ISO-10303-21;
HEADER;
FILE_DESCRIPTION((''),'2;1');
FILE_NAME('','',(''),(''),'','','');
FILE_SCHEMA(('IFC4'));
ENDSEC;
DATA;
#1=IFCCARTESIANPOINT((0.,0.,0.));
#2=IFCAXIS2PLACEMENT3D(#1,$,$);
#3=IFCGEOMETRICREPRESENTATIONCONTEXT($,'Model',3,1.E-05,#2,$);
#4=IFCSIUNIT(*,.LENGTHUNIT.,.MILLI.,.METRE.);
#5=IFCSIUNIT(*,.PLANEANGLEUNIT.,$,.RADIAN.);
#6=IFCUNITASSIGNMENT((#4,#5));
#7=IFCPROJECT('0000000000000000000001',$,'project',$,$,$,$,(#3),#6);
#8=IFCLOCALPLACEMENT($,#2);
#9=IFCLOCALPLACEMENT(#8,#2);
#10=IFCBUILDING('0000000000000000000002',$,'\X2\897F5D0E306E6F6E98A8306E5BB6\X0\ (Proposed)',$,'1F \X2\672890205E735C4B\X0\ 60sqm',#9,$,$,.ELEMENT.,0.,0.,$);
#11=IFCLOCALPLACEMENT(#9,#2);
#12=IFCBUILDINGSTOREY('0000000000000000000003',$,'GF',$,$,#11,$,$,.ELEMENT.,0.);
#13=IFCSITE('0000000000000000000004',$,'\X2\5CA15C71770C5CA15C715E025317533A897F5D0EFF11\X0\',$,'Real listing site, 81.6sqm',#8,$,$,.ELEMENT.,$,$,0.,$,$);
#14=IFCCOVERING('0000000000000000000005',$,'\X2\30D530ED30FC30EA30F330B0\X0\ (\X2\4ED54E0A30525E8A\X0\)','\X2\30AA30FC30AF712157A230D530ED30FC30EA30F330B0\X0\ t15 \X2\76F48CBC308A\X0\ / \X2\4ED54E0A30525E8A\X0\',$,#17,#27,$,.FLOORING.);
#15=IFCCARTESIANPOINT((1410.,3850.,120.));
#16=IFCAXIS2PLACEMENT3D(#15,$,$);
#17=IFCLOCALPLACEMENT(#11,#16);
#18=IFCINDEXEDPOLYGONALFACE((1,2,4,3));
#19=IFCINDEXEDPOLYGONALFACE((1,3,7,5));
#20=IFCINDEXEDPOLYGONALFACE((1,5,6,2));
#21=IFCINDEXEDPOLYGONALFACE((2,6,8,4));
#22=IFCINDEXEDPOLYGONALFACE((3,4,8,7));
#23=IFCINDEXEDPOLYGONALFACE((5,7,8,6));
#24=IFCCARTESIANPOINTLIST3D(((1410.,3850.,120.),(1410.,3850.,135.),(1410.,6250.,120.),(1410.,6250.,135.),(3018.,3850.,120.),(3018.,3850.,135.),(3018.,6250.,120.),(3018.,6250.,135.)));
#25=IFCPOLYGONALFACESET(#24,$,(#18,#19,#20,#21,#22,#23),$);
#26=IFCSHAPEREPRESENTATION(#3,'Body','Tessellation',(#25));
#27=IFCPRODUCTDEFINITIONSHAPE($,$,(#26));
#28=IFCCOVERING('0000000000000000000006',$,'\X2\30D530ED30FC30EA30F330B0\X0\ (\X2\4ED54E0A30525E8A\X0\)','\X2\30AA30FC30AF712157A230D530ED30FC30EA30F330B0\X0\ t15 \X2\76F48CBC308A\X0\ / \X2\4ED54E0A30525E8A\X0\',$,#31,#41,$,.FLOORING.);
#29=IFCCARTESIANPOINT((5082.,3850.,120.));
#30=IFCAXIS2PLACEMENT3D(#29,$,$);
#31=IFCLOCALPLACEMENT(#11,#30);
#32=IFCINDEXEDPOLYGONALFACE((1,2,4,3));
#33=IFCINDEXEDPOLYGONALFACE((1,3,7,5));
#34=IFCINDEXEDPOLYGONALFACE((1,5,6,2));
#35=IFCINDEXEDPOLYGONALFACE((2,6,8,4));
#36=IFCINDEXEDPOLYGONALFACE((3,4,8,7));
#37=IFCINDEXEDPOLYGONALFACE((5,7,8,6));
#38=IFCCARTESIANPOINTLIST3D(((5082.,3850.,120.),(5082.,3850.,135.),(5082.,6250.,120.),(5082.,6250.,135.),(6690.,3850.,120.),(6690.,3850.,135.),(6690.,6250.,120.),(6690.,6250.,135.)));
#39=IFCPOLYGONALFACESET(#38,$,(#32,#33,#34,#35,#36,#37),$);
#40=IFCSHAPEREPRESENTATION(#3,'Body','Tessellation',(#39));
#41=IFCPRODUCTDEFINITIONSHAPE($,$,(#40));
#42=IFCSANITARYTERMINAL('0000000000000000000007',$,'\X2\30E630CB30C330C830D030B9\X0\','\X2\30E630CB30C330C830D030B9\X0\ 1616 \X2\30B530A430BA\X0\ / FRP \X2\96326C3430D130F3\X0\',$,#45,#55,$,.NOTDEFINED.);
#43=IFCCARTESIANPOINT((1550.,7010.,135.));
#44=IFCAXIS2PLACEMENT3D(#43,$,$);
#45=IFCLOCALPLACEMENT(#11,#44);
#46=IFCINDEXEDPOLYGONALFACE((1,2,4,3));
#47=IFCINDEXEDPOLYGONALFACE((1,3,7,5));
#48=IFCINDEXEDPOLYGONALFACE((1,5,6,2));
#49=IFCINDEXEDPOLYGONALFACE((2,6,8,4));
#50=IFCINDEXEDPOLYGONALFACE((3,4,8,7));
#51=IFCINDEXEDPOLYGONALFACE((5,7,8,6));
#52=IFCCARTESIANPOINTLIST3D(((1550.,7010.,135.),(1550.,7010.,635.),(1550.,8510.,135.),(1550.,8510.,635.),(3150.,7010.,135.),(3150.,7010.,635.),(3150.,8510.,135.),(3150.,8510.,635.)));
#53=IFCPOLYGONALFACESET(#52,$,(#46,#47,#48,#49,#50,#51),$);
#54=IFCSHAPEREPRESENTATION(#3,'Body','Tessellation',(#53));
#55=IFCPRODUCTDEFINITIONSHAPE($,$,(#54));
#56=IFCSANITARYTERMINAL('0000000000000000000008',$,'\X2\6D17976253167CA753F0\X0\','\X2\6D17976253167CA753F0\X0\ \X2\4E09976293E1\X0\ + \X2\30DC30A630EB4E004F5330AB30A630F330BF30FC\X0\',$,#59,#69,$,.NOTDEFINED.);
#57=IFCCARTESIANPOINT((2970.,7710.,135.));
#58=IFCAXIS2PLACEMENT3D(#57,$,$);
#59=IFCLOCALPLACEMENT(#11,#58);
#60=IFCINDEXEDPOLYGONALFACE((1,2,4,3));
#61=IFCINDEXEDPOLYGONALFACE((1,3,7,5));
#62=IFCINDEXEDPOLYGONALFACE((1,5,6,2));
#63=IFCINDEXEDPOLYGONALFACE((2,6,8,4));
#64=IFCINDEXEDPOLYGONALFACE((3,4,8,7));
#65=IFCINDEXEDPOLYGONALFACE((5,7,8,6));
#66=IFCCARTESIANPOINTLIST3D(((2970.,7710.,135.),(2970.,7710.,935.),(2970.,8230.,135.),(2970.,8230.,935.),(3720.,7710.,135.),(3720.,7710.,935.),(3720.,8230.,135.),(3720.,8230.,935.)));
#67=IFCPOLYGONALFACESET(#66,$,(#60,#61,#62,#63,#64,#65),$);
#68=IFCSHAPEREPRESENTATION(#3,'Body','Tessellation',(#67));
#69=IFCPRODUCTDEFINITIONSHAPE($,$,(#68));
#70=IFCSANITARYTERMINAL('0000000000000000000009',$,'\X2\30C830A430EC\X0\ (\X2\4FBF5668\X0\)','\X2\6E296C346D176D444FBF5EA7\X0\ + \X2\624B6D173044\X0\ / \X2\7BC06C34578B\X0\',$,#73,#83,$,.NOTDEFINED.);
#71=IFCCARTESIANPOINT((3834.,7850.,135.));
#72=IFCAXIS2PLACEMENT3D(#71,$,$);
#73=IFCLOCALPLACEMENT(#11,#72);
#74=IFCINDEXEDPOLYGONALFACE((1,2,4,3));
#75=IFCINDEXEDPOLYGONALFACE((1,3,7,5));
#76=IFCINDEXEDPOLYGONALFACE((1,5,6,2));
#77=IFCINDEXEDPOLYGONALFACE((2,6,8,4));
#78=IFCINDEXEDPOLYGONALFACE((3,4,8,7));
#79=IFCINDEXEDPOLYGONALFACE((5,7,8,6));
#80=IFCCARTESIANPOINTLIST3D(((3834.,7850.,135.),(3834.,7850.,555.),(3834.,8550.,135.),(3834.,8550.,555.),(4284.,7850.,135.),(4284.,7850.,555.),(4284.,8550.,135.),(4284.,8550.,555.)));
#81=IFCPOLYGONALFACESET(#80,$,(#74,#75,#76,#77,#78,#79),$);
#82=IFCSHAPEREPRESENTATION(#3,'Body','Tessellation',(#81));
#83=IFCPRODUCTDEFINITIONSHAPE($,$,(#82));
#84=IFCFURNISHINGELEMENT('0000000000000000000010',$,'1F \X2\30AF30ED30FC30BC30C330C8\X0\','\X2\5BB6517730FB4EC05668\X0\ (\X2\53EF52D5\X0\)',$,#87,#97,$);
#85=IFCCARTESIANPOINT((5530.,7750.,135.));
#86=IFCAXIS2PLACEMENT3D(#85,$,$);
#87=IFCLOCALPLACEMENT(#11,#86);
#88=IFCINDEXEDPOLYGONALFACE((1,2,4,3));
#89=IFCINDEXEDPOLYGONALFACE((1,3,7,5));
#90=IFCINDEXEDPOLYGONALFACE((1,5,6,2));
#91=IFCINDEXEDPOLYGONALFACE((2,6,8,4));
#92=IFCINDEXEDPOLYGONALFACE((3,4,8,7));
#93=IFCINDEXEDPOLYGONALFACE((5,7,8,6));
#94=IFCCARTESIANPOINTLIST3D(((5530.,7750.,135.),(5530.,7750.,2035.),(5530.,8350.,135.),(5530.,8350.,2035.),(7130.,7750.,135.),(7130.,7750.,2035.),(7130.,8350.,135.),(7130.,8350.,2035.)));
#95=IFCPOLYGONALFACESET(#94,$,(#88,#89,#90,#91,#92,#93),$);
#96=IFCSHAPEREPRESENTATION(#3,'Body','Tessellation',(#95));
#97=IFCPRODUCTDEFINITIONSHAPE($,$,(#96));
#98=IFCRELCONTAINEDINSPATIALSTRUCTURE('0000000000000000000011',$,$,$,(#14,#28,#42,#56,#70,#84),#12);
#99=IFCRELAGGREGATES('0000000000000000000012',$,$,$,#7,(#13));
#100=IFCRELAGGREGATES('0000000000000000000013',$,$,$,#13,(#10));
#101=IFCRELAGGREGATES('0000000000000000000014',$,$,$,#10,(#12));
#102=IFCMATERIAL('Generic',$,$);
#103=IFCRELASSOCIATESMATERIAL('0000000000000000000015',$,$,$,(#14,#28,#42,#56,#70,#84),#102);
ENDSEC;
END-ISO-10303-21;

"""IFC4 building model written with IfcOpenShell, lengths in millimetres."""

from ifc_helpers import new_model, si_unit, frame, frame_2d, origin, place, context, project, spatial, rectangle, extrude, material, element, save


model = new_model("IFC4")

# Units and contexts
model_context = context("Model", 3, precision=1e-05, world=origin())
ifc_project = project(units=[si_unit("LENGTHUNIT", "METRE", prefix="MILLI"), si_unit("PLANEANGLEUNIT", "RADIAN")], contexts=[model_context])

# Site, building, storey
site_placement = place(None, origin())
site = spatial("IfcSite", under=ifc_project, at=site_placement, Name="岡山県岡山市北区西崎１", ObjectType="Real listing site, 81.6sqm", CompositionType="ELEMENT", RefElevation=0.0)
building_placement = place(site_placement, origin())
building = spatial("IfcBuilding", under=site, at=building_placement, Name="西崎の潮風の家 (Proposed)", ObjectType="1F 木造平屋 60sqm", CompositionType="ELEMENT", ElevationOfRefHeight=0.0, ElevationOfTerrain=0.0)
storey_placement = place(building_placement, origin())
storey = spatial("IfcBuildingStorey", under=building, at=storey_placement, Name="GF", CompositionType="ELEMENT", Elevation=0.0)

# Coverings
ifc_material_1 = material(Name="Generic")
covering_1_placement = place(storey_placement, frame((1410.0, 3850.0, 120.0)))
element("IfcCovering", 1, at=covering_1_placement, inside=storey, material=ifc_material_1, Name="フローリング (仕上げ床)", Description="オーク無垢フローリング t15 直貼り / 仕上げ床", PredefinedType="FLOORING", context=model_context, shape_type="SweptSolid", body=[
    extrude(rectangle(XDim=1608.0, YDim=2400.0, at=frame_2d((804.0, 1200.0))), frame((1410.0, 3850.0, 120.0)), (0.0, 0.0, 1.0), 15.0),
])
covering_2_placement = place(storey_placement, frame((5082.0, 3850.0, 120.0)))
element("IfcCovering", 2, at=covering_2_placement, inside=storey, material=ifc_material_1, Name="フローリング (仕上げ床)", Description="オーク無垢フローリング t15 直貼り / 仕上げ床", PredefinedType="FLOORING", context=model_context, shape_type="SweptSolid", body=[
    extrude(rectangle(XDim=1608.0, YDim=2400.0, at=frame_2d((804.0, 1200.0))), frame((5082.0, 3850.0, 120.0)), (0.0, 0.0, 1.0), 15.0),
])

# Sanitary terminals
sanitary_terminal_1_placement = place(storey_placement, frame((1550.0, 7010.0, 135.0)))
element("IfcSanitaryTerminal", 3, at=sanitary_terminal_1_placement, inside=storey, material=ifc_material_1, Name="ユニットバス", Description="ユニットバス 1616 サイズ / FRP 防水パン", PredefinedType="NOTDEFINED", context=model_context, shape_type="SweptSolid", body=[
    extrude(rectangle(XDim=1600.0, YDim=1500.0, at=frame_2d((800.0, 750.0))), frame((1550.0, 7010.0, 135.0)), (0.0, 0.0, 1.0), 500.0),
])
sanitary_terminal_2_placement = place(storey_placement, frame((2970.0, 7710.0, 135.0)))
element("IfcSanitaryTerminal", 4, at=sanitary_terminal_2_placement, inside=storey, material=ifc_material_1, Name="洗面化粧台", Description="洗面化粧台 三面鏡 + ボウル一体カウンター", PredefinedType="NOTDEFINED", context=model_context, shape_type="SweptSolid", body=[
    extrude(rectangle(XDim=750.0, YDim=520.0, at=frame_2d((375.0, 260.0))), frame((2970.0, 7710.0, 135.0)), (0.0, 0.0, 1.0), 800.0),
])
sanitary_terminal_3_placement = place(storey_placement, frame((3834.0, 7850.0, 135.0)))
element("IfcSanitaryTerminal", 5, at=sanitary_terminal_3_placement, inside=storey, material=ifc_material_1, Name="トイレ (便器)", Description="温水洗浄便座 + 手洗い / 節水型", PredefinedType="NOTDEFINED", context=model_context, shape_type="SweptSolid", body=[
    extrude(rectangle(XDim=450.0, YDim=700.0, at=frame_2d((225.0, 350.0))), frame((3834.0, 7850.0, 135.0)), (0.0, 0.0, 1.0), 420.0),
])

# Furnishing element
furnishing_placement = place(storey_placement, frame((5530.0, 7750.0, 135.0)))
element("IfcFurnishingElement", 6, at=furnishing_placement, inside=storey, material=ifc_material_1, Name="1F クローゼット", Description="家具・什器 (可動)", context=model_context, shape_type="SweptSolid", body=[
    extrude(rectangle(XDim=1600.0, YDim=600.0, at=frame_2d((800.0, 300.0))), frame((5530.0, 7750.0, 135.0)), (0.0, 0.0, 1.0), 1900.0),
])

save(model, "model.ifc")
